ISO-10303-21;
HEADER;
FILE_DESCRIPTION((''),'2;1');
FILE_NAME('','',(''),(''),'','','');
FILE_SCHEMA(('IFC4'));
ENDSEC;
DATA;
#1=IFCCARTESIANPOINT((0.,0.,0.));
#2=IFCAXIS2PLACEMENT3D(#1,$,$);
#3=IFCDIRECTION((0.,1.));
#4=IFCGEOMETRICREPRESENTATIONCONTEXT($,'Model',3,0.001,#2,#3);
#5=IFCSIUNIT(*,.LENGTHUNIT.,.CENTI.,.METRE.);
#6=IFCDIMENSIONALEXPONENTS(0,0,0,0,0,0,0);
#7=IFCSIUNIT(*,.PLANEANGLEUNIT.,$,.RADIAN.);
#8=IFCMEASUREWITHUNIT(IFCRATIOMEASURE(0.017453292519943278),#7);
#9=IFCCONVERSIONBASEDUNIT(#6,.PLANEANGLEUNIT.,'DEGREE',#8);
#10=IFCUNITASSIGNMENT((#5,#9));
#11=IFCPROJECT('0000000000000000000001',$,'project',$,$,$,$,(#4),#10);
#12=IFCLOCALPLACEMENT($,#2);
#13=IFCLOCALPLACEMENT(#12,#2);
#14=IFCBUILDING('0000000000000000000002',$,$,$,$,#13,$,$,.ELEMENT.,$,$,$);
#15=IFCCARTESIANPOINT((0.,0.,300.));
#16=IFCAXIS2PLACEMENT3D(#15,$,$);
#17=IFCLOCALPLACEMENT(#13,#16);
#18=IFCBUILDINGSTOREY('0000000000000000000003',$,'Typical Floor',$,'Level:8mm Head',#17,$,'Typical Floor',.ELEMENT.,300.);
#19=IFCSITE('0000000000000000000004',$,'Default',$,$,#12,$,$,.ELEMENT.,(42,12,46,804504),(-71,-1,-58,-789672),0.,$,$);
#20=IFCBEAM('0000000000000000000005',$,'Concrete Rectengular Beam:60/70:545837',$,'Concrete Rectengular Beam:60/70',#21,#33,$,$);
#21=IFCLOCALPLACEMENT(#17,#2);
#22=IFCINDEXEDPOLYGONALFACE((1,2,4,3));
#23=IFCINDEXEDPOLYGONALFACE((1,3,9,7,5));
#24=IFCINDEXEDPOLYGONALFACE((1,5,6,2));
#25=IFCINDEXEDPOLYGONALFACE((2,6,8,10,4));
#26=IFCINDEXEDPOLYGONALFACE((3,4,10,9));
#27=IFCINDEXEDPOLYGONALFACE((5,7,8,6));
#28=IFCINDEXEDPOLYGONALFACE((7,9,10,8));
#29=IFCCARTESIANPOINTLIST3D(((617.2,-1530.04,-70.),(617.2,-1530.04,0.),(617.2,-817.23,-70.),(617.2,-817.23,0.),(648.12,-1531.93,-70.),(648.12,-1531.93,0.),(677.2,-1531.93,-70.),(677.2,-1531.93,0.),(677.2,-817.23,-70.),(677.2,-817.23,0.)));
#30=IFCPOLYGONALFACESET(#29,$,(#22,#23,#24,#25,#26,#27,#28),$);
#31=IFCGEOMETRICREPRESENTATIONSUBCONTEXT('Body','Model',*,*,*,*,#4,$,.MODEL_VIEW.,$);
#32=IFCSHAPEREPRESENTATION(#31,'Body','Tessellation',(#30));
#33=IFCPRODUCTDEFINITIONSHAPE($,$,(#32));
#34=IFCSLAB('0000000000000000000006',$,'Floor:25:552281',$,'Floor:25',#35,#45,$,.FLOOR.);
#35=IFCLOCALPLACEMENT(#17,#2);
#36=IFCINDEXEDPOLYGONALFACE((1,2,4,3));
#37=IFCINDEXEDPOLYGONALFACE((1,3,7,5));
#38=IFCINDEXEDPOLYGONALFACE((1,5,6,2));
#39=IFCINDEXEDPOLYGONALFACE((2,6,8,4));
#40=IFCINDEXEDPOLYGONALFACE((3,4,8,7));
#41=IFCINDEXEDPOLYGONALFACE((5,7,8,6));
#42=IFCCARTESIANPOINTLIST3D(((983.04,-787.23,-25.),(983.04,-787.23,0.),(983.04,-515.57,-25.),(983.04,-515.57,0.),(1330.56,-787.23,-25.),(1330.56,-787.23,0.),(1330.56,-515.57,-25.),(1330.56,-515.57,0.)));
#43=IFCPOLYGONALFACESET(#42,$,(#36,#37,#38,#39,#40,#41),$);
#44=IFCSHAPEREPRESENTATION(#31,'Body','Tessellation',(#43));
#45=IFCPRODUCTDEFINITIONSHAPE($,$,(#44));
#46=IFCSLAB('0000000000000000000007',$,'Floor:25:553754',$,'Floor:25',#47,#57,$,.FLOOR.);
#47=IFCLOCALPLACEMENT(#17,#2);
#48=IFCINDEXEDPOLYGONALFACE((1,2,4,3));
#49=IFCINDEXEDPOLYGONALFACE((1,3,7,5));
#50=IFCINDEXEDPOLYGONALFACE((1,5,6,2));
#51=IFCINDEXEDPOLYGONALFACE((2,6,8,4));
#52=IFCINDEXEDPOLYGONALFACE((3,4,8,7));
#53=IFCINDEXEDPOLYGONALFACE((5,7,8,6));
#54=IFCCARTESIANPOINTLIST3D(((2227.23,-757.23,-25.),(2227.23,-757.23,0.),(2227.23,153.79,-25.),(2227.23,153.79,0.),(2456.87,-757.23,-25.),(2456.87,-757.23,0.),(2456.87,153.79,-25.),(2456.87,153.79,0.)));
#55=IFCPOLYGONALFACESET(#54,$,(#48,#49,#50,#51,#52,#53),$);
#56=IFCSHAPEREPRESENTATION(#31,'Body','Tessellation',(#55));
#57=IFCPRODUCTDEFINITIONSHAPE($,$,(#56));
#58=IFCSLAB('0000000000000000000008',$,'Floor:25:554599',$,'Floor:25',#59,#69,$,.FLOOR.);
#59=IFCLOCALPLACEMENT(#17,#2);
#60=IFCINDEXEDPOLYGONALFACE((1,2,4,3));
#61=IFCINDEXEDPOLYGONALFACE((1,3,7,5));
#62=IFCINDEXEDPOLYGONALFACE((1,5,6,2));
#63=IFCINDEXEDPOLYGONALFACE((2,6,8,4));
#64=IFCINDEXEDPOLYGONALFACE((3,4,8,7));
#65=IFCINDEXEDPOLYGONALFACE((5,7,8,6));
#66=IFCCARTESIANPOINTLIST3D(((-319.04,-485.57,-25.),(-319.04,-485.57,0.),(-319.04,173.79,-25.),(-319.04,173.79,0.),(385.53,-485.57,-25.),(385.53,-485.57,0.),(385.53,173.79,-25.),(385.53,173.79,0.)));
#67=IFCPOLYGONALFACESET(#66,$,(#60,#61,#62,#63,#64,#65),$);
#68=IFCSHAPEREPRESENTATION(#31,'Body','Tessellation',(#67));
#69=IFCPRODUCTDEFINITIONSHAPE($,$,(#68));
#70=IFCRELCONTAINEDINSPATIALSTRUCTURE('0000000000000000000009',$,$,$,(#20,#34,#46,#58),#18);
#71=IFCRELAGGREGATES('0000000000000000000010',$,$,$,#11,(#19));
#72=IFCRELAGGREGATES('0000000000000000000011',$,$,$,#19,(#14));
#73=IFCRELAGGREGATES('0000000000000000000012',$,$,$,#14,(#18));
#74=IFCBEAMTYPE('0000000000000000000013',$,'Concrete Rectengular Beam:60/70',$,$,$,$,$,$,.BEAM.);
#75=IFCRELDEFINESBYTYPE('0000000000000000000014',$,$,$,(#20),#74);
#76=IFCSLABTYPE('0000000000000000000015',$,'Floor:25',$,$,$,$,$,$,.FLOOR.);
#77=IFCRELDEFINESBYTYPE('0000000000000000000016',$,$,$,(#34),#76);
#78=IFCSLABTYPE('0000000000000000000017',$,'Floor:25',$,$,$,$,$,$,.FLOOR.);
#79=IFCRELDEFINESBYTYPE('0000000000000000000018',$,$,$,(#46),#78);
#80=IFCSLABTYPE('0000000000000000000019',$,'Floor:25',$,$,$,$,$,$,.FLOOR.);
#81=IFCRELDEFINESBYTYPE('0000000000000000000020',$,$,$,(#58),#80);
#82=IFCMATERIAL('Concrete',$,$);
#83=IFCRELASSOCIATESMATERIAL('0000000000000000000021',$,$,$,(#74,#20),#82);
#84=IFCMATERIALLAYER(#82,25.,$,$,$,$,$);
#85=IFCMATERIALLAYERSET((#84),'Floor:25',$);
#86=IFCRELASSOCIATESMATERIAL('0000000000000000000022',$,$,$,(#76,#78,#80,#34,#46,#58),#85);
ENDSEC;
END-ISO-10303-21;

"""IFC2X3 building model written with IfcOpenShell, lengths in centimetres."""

from ifc_helpers import new_model, entity, si_unit, converted_unit, direction, frame, frame_2d, origin, origin_2d_with_axis, place, context, subcontext, project, spatial, rectangle, extrude, clip, halfspace, material, layer, layer_set, layer_usage, type_object, element, save


model = new_model("IFC2X3")

# Units and contexts
model_context = context("Model", 3, precision=0.001, world=origin(), true_north=direction((0.0, 1.0)))
body_context = subcontext(model_context, "Body", "Model", "MODEL_VIEW")
ifc_project = project(units=[si_unit("LENGTHUNIT", "METRE", prefix="CENTI"), converted_unit("PLANEANGLEUNIT", "DEGREE", entity("IfcRatioMeasure", 0.017453292519943278), si_unit("PLANEANGLEUNIT", "RADIAN"), dimensions=[0, 0, 0, 0, 0, 0, 0])], contexts=[model_context])

# Site, building, storey
site_placement = place(None, origin())
site = spatial("IfcSite", under=ifc_project, at=site_placement, Name="Default", CompositionType="ELEMENT", RefLatitude=(42, 12, 46, 804504), RefLongitude=(-71, -1, -58, -789672), RefElevation=0.0)
building_placement = place(site_placement, origin())
building = spatial("IfcBuilding", under=site, at=building_placement, CompositionType="ELEMENT")
storey_placement = place(building_placement, frame((0.0, 0.0, 300.0)))
storey = spatial("IfcBuildingStorey", under=building, at=storey_placement, Name="Typical Floor", ObjectType="Level:8mm Head", LongName="Typical Floor", CompositionType="ELEMENT", Elevation=300.0)

# Beam
ifc_material = material(Name="Concrete")
beam_type = type_object("IfcBeamType", Name="Concrete Rectengular Beam:60/70", PredefinedType="BEAM", material=ifc_material)
beam_1_placement = place(storey_placement, frame((647.2, -1561.93, 0.0), z_axis=(0.0, 0.0, 1.0), x_axis=(0.0, 1.0, 0.0)))
element("IfcBeam", 1, at=beam_1_placement, inside=storey, type_object=beam_type, material=ifc_material, Name="Concrete Rectengular Beam:60/70:545837", ObjectType="Concrete Rectengular Beam:60/70", context=body_context, shape_type="SweptSolid", body=[
    clip(extrude(rectangle(XDim=70.0, YDim=60.0, at=frame_2d((0.0, 0.0), x_axis=(1.0, 0.0))), frame((30.0, 0.0, -35.0), z_axis=(1.0, 0.0, 0.0), x_axis=(0.0, 0.0, -1.0)), (0.0, 0.0, 1.0), 714.7), halfspace(frame((69.95, 652.66, 0.0), z_axis=(-0.998138, 0.061004, 0.0), x_axis=(-0.061004, -0.998138, 0.0)), False)),
])

# Slabs
ifc_layer_1 = layer(ifc_material, 25.0)
ifc_layer_set_1 = layer_set([ifc_layer_1], Name="Floor:25")
ifc_layer_usage_1 = layer_usage(ifc_layer_set_1, "AXIS3", "POSITIVE", 0.0)
slab_type_1 = type_object("IfcSlabType", Name="Floor:25", PredefinedType="FLOOR", material=ifc_layer_set_1)
slab_1_placement = place(storey_placement, origin())
element("IfcSlab", 2, at=slab_1_placement, inside=storey, type_object=slab_type_1, material=ifc_layer_usage_1, Name="Floor:25:552281", ObjectType="Floor:25", PredefinedType="FLOOR", context=body_context, shape_type="SweptSolid", body=[
    extrude(rectangle(XDim=271.66, YDim=347.52, at=frame_2d((0.0, 0.0), x_axis=(1.0, 0.0))), frame((1156.8, -651.4, 0.0), z_axis=(0.0, 0.0, -1.0), x_axis=(0.0, 1.0, 0.0)), (0.0, 0.0, 1.0), 25.0),
])
ifc_layer_usage_2 = layer_usage(ifc_layer_set_1, "AXIS3", "POSITIVE", 0.0)
slab_type_2 = type_object("IfcSlabType", Name="Floor:25", PredefinedType="FLOOR", material=ifc_layer_set_1)
slab_2_placement = place(storey_placement, origin())
element("IfcSlab", 3, at=slab_2_placement, inside=storey, type_object=slab_type_2, material=ifc_layer_usage_2, Name="Floor:25:553754", ObjectType="Floor:25", PredefinedType="FLOOR", context=body_context, shape_type="SweptSolid", body=[
    extrude(rectangle(XDim=911.01, YDim=229.64, at=frame_2d((0.0, 0.0), x_axis=(1.0, 0.0))), frame((2342.05, -301.72, 0.0), z_axis=(0.0, 0.0, -1.0), x_axis=(0.0, 1.0, 0.0)), (0.0, 0.0, 1.0), 25.0),
])
ifc_layer_usage_3 = layer_usage(ifc_layer_set_1, "AXIS3", "POSITIVE", 0.0)
slab_type_3 = type_object("IfcSlabType", Name="Floor:25", PredefinedType="FLOOR", material=ifc_layer_set_1)
slab_3_placement = place(storey_placement, origin())
element("IfcSlab", 4, at=slab_3_placement, inside=storey, type_object=slab_type_3, material=ifc_layer_usage_3, Name="Floor:25:554599", ObjectType="Floor:25", PredefinedType="FLOOR", context=body_context, shape_type="SweptSolid", body=[
    extrude(rectangle(XDim=659.35, YDim=704.57, at=origin_2d_with_axis()), frame((33.25, -155.89, 0.0), z_axis=(0.0, 0.0, -1.0), x_axis=(0.0, 1.0, 0.0)), (0.0, 0.0, 1.0), 25.0),
])

save(model, "model.ifc")
